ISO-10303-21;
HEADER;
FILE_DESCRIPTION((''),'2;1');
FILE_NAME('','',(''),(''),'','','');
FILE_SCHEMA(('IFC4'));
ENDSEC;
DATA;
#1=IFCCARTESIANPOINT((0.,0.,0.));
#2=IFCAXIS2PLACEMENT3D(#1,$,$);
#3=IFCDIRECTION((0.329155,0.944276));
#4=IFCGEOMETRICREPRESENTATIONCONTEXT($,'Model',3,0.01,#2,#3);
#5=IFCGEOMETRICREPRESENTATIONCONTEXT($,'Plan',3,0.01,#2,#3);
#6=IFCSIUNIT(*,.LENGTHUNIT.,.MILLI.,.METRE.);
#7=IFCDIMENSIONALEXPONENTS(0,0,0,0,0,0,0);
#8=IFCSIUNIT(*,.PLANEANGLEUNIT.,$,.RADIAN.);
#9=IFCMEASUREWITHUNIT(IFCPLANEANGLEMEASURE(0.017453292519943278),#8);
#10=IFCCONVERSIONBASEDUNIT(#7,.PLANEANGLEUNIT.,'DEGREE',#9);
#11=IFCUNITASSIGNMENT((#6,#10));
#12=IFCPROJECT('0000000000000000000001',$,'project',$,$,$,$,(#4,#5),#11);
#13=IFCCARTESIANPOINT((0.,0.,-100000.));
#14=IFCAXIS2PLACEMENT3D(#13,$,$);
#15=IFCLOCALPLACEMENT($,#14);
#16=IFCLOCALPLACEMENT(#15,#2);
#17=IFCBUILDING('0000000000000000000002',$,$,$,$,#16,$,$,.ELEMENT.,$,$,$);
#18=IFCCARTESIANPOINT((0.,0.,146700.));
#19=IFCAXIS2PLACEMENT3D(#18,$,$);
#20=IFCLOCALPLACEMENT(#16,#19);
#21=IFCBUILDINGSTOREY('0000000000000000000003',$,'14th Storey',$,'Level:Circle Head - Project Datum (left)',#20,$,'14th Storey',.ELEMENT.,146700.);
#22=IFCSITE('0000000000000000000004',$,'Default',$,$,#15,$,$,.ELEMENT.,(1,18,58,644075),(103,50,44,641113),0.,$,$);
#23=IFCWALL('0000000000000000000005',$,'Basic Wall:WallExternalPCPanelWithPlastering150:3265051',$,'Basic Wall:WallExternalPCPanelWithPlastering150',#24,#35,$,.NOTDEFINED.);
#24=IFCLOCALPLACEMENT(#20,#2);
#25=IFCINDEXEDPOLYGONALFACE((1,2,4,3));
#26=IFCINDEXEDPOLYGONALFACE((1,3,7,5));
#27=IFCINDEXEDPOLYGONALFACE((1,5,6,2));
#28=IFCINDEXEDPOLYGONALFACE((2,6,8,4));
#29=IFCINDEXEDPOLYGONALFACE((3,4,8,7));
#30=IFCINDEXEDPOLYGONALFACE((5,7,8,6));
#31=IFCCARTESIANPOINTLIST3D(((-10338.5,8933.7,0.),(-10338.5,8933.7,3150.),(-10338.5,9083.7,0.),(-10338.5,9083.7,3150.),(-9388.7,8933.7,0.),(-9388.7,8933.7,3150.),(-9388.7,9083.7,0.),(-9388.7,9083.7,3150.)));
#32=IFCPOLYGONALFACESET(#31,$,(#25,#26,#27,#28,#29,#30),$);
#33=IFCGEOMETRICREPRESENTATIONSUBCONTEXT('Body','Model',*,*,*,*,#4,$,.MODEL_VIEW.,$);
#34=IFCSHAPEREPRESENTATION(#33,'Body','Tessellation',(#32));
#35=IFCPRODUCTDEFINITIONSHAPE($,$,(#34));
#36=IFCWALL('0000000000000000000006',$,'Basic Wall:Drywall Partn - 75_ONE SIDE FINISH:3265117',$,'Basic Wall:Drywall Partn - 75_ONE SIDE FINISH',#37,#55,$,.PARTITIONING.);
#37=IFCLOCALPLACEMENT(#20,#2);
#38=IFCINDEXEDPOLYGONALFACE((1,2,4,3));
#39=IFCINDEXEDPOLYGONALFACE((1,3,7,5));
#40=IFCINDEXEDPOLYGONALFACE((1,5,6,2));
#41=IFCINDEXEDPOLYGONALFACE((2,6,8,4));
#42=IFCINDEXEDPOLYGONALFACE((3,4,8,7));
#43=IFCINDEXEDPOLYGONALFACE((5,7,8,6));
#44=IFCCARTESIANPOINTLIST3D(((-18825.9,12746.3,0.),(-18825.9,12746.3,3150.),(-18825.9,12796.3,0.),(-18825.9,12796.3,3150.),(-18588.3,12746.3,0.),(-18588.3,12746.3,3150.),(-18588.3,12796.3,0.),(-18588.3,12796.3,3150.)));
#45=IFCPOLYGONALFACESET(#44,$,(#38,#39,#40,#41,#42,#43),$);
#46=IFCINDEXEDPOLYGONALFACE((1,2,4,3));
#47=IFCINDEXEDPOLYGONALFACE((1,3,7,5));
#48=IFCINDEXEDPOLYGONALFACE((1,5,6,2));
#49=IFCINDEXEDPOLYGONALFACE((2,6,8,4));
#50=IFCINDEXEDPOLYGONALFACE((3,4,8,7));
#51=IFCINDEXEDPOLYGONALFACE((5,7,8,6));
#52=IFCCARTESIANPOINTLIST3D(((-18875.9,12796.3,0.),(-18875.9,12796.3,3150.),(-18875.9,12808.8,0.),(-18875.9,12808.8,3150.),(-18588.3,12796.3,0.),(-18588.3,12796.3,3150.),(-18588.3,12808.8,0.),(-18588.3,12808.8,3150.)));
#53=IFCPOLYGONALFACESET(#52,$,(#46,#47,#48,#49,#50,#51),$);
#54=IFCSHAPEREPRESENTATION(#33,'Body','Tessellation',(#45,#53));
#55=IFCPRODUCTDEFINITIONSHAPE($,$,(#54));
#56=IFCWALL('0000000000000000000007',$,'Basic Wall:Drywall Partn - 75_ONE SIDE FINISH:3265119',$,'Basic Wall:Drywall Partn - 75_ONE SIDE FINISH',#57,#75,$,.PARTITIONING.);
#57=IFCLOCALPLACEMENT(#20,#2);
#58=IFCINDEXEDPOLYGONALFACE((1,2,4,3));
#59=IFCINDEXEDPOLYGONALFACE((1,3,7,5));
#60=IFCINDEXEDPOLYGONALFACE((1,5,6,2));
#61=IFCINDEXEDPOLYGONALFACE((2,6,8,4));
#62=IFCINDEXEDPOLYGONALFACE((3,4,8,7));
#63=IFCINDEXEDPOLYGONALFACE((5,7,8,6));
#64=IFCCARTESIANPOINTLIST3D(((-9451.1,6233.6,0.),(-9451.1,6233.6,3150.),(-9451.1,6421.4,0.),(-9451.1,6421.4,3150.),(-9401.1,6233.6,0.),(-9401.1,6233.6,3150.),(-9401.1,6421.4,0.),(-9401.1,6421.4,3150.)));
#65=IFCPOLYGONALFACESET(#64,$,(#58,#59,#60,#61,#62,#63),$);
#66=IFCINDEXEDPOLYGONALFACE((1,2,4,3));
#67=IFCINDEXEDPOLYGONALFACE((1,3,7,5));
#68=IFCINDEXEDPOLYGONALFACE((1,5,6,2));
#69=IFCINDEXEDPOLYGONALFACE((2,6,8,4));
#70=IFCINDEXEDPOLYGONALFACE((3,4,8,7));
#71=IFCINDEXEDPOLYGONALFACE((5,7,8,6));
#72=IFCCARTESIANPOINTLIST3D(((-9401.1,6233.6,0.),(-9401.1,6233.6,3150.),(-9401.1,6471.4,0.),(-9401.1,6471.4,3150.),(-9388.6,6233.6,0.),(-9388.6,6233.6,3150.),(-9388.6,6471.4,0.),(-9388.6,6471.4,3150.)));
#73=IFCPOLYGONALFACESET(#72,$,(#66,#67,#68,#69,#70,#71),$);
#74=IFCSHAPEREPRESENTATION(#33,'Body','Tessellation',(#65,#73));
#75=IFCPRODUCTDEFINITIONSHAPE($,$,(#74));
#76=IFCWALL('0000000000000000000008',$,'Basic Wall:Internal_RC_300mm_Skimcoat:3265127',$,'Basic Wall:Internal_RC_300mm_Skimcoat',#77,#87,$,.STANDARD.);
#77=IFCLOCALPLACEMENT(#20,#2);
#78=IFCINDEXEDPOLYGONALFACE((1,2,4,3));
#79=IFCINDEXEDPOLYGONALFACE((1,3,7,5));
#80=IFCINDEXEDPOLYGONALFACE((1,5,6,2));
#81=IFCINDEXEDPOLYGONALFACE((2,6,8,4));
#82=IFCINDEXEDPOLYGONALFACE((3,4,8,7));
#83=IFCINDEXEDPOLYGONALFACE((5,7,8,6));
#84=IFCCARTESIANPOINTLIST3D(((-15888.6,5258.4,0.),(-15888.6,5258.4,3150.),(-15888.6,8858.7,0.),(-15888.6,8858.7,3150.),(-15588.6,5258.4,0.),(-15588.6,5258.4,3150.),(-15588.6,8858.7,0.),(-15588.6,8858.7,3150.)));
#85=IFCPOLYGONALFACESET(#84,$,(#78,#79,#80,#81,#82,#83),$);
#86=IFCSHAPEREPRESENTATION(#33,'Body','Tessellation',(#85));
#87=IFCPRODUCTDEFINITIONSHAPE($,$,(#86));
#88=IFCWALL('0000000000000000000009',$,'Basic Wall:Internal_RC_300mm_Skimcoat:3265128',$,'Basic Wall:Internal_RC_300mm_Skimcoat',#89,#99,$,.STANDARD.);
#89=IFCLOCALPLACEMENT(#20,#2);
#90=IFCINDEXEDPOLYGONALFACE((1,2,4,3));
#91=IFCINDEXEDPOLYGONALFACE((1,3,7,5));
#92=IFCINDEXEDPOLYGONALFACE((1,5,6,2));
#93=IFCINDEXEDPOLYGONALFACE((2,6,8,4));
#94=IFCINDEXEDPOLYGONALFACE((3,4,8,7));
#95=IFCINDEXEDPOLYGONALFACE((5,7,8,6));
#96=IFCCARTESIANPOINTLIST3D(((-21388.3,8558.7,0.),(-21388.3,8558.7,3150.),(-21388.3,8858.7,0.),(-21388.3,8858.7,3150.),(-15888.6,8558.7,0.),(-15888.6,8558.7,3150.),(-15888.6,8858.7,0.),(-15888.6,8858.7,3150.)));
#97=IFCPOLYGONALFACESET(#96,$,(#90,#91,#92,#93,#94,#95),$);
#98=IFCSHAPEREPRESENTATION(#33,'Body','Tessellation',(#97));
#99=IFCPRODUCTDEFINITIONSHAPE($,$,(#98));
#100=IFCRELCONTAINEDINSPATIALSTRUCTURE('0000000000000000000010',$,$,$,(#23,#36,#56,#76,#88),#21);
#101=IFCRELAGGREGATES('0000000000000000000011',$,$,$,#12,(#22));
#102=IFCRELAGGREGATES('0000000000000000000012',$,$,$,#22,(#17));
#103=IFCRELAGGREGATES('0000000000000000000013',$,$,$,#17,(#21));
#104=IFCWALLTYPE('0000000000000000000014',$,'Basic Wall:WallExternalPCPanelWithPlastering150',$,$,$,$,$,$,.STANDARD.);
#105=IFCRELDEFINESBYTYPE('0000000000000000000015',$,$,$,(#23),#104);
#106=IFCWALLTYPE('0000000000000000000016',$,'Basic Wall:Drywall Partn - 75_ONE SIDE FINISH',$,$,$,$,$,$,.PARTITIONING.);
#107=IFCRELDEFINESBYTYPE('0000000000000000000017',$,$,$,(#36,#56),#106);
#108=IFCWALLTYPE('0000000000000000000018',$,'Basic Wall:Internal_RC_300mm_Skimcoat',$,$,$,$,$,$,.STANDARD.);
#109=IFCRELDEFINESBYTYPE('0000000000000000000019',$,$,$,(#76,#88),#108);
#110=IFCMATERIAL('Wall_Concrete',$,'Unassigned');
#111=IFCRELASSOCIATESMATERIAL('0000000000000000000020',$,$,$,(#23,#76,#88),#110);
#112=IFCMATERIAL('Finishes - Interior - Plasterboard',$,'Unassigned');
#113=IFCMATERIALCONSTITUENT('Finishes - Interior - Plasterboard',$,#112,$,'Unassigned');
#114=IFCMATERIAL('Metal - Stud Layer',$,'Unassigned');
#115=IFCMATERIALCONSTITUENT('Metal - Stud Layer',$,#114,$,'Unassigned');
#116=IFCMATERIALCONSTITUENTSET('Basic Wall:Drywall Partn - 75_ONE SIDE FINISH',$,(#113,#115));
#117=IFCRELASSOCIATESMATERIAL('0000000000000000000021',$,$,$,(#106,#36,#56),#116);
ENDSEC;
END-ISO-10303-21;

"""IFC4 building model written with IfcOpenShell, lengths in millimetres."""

from ifc_helpers import new_model, entity, si_unit, converted_unit, direction, frame, origin, place, context, subcontext, project, spatial, indexed_curve, outline, extrude, material, constituent, constituent_set, type_object, element, save


model = new_model("IFC4")

# Units and contexts
model_context = context("Model", 3, precision=0.01, world=origin(), true_north=direction((0.329155, 0.944276)))
plan_context = context("Plan", 3, precision=0.01, world=origin(), true_north=direction((0.329155, 0.944276)))
body_context = subcontext(model_context, "Body", "Model", "MODEL_VIEW")
ifc_project = project(units=[si_unit("LENGTHUNIT", "METRE", prefix="MILLI"), converted_unit("PLANEANGLEUNIT", "DEGREE", entity("IfcPlaneAngleMeasure", 0.017453292519943278), si_unit("PLANEANGLEUNIT", "RADIAN"), dimensions=[0, 0, 0, 0, 0, 0, 0])], contexts=[model_context, plan_context])

# Site, building, storey
site_placement = place(None, frame((0.0, 0.0, -100000.0)))
site = spatial("IfcSite", under=ifc_project, at=site_placement, Name="Default", CompositionType="ELEMENT", RefLatitude=(1, 18, 58, 644075), RefLongitude=(103, 50, 44, 641113), RefElevation=0.0)
building_placement = place(site_placement, origin())
building = spatial("IfcBuilding", under=site, at=building_placement, CompositionType="ELEMENT")
storey_placement = place(building_placement, frame((0.0, 0.0, 146700.0)))
storey = spatial("IfcBuildingStorey", under=building, at=storey_placement, Name="14th Storey", ObjectType="Level:Circle Head - Project Datum (left)", LongName="14th Storey", CompositionType="ELEMENT", Elevation=146700.0)

# Walls
ifc_material_1 = material(Name="Wall_Concrete", Category="Unassigned")
ifc_material_2 = material(Name="Metal - Stud Layer", Category="Unassigned")
wall_type_1 = type_object("IfcWallType", Name="Basic Wall:WallExternalPCPanelWithPlastering150", PredefinedType="STANDARD")
wall_1_placement = place(storey_placement, frame((-9388.7, 9008.7, 0.0), z_axis=(0.0, 0.0, 1.0), x_axis=(-1.0, 0.0, 0.0)))
element("IfcWall", 1, at=wall_1_placement, inside=storey, type_object=wall_type_1, material=ifc_material_1, Name="Basic Wall:WallExternalPCPanelWithPlastering150:3265051", ObjectType="Basic Wall:WallExternalPCPanelWithPlastering150", PredefinedType="NOTDEFINED", context=body_context, shape_type="SweptSolid", body=[
    extrude(outline(indexed_curve([(949.7, 75.0), (0.0, 75.0), (0.0, -75.0), (949.7, -75.0), (949.7, 75.0)], self_intersect=False)), origin(), (0.0, 0.0, 1.0), 3150.0),
])
ifc_material_3 = material(Name="Finishes - Interior - Plasterboard", Category="Unassigned")
ifc_constituent_1 = constituent(ifc_material_3, Name="Finishes - Interior - Plasterboard", Category="Unassigned")
ifc_constituent_2 = constituent(ifc_material_2, Name="Metal - Stud Layer", Category="Unassigned")
ifc_constituent_set = constituent_set(constituents=[ifc_constituent_1, ifc_constituent_2], Name="Basic Wall:Drywall Partn - 75_ONE SIDE FINISH")
wall_type_2 = type_object("IfcWallType", Name="Basic Wall:Drywall Partn - 75_ONE SIDE FINISH", PredefinedType="PARTITIONING", material=ifc_constituent_set)
wall_2_placement = place(storey_placement, frame((-18825.9, 12777.5, 0.0)))
element("IfcWall", 2, at=wall_2_placement, inside=storey, type_object=wall_type_2, material=ifc_constituent_set, Name="Basic Wall:Drywall Partn - 75_ONE SIDE FINISH:3265117", ObjectType="Basic Wall:Drywall Partn - 75_ONE SIDE FINISH", PredefinedType="PARTITIONING", context=body_context, shape_type="SweptSolid", body=[
    extrude(outline(indexed_curve([(-25.0, -118.8), (25.0, -118.8), (25.0, 118.8), (-25.0, 118.8), (-25.0, -118.8)], self_intersect=False)), frame((118.8, -6.3, 0.0), z_axis=(0.0, 0.0, 1.0), x_axis=(0.0, 1.0, 0.0)), (0.0, 0.0, 1.0), 3150.0),
    extrude(outline(indexed_curve([(-6.3, -143.8), (6.2, -143.8), (6.2, 143.8), (-6.3, 143.8), (-6.3, -143.8)], self_intersect=False)), frame((93.8, 25.0, 0.0), z_axis=(0.0, 0.0, 1.0), x_axis=(0.0, -1.0, 0.0)), (0.0, 0.0, 1.0), 3150.0),
])
wall_3_placement = place(storey_placement, frame((-9419.8, 6421.4, 0.0), z_axis=(0.0, 0.0, 1.0), x_axis=(0.0, -1.0, 0.0)))
element("IfcWall", 3, at=wall_3_placement, inside=storey, type_object=wall_type_2, material=ifc_constituent_set, Name="Basic Wall:Drywall Partn - 75_ONE SIDE FINISH:3265119", ObjectType="Basic Wall:Drywall Partn - 75_ONE SIDE FINISH", PredefinedType="PARTITIONING", context=body_context, shape_type="SweptSolid", body=[
    extrude(outline(indexed_curve([(-25.0, -93.9), (25.0, -93.9), (25.0, 93.9), (-25.0, 93.9), (-25.0, -93.9)], self_intersect=False)), frame((93.9, -6.2, 0.0), z_axis=(0.0, 0.0, 1.0), x_axis=(0.0, 1.0, 0.0)), (0.0, 0.0, 1.0), 3150.0),
    extrude(outline(indexed_curve([(-6.3, -118.9), (6.2, -118.9), (6.2, 118.9), (-6.3, 118.9), (-6.3, -118.9)], self_intersect=False)), frame((68.9, 25.0, 0.0), z_axis=(0.0, 0.0, 1.0), x_axis=(0.0, -1.0, 0.0)), (0.0, 0.0, 1.0), 3150.0),
])
wall_type_3 = type_object("IfcWallType", Name="Basic Wall:Internal_RC_300mm_Skimcoat", PredefinedType="STANDARD")
wall_4_placement = place(storey_placement, frame((-15738.6, 8858.7, 0.0), z_axis=(0.0, 0.0, 1.0), x_axis=(0.0, -1.0, 0.0)))
element("IfcWall", 4, at=wall_4_placement, inside=storey, type_object=wall_type_3, material=ifc_material_1, Name="Basic Wall:Internal_RC_300mm_Skimcoat:3265127", ObjectType="Basic Wall:Internal_RC_300mm_Skimcoat", PredefinedType="STANDARD", context=body_context, shape_type="SweptSolid", body=[
    extrude(outline(indexed_curve([(3600.4, 150.0), (0.0, 150.0), (0.0, -150.0), (3600.4, -150.0), (3600.4, 150.0)], self_intersect=False)), origin(), (0.0, 0.0, 1.0), 3150.0),
])
wall_5_placement = place(storey_placement, frame((-15888.6, 8708.7, 0.0), z_axis=(0.0, 0.0, 1.0), x_axis=(-1.0, 0.0, 0.0)))
element("IfcWall", 5, at=wall_5_placement, inside=storey, type_object=wall_type_3, material=ifc_material_1, Name="Basic Wall:Internal_RC_300mm_Skimcoat:3265128", ObjectType="Basic Wall:Internal_RC_300mm_Skimcoat", PredefinedType="STANDARD", context=body_context, shape_type="SweptSolid", body=[
    extrude(outline(indexed_curve([(5499.7, 150.0), (0.0, 150.0), (0.0, -150.0), (5499.7, -150.0), (5499.7, 150.0)], self_intersect=False)), origin(), (0.0, 0.0, 1.0), 3150.0),
])

save(model, "model.ifc")
